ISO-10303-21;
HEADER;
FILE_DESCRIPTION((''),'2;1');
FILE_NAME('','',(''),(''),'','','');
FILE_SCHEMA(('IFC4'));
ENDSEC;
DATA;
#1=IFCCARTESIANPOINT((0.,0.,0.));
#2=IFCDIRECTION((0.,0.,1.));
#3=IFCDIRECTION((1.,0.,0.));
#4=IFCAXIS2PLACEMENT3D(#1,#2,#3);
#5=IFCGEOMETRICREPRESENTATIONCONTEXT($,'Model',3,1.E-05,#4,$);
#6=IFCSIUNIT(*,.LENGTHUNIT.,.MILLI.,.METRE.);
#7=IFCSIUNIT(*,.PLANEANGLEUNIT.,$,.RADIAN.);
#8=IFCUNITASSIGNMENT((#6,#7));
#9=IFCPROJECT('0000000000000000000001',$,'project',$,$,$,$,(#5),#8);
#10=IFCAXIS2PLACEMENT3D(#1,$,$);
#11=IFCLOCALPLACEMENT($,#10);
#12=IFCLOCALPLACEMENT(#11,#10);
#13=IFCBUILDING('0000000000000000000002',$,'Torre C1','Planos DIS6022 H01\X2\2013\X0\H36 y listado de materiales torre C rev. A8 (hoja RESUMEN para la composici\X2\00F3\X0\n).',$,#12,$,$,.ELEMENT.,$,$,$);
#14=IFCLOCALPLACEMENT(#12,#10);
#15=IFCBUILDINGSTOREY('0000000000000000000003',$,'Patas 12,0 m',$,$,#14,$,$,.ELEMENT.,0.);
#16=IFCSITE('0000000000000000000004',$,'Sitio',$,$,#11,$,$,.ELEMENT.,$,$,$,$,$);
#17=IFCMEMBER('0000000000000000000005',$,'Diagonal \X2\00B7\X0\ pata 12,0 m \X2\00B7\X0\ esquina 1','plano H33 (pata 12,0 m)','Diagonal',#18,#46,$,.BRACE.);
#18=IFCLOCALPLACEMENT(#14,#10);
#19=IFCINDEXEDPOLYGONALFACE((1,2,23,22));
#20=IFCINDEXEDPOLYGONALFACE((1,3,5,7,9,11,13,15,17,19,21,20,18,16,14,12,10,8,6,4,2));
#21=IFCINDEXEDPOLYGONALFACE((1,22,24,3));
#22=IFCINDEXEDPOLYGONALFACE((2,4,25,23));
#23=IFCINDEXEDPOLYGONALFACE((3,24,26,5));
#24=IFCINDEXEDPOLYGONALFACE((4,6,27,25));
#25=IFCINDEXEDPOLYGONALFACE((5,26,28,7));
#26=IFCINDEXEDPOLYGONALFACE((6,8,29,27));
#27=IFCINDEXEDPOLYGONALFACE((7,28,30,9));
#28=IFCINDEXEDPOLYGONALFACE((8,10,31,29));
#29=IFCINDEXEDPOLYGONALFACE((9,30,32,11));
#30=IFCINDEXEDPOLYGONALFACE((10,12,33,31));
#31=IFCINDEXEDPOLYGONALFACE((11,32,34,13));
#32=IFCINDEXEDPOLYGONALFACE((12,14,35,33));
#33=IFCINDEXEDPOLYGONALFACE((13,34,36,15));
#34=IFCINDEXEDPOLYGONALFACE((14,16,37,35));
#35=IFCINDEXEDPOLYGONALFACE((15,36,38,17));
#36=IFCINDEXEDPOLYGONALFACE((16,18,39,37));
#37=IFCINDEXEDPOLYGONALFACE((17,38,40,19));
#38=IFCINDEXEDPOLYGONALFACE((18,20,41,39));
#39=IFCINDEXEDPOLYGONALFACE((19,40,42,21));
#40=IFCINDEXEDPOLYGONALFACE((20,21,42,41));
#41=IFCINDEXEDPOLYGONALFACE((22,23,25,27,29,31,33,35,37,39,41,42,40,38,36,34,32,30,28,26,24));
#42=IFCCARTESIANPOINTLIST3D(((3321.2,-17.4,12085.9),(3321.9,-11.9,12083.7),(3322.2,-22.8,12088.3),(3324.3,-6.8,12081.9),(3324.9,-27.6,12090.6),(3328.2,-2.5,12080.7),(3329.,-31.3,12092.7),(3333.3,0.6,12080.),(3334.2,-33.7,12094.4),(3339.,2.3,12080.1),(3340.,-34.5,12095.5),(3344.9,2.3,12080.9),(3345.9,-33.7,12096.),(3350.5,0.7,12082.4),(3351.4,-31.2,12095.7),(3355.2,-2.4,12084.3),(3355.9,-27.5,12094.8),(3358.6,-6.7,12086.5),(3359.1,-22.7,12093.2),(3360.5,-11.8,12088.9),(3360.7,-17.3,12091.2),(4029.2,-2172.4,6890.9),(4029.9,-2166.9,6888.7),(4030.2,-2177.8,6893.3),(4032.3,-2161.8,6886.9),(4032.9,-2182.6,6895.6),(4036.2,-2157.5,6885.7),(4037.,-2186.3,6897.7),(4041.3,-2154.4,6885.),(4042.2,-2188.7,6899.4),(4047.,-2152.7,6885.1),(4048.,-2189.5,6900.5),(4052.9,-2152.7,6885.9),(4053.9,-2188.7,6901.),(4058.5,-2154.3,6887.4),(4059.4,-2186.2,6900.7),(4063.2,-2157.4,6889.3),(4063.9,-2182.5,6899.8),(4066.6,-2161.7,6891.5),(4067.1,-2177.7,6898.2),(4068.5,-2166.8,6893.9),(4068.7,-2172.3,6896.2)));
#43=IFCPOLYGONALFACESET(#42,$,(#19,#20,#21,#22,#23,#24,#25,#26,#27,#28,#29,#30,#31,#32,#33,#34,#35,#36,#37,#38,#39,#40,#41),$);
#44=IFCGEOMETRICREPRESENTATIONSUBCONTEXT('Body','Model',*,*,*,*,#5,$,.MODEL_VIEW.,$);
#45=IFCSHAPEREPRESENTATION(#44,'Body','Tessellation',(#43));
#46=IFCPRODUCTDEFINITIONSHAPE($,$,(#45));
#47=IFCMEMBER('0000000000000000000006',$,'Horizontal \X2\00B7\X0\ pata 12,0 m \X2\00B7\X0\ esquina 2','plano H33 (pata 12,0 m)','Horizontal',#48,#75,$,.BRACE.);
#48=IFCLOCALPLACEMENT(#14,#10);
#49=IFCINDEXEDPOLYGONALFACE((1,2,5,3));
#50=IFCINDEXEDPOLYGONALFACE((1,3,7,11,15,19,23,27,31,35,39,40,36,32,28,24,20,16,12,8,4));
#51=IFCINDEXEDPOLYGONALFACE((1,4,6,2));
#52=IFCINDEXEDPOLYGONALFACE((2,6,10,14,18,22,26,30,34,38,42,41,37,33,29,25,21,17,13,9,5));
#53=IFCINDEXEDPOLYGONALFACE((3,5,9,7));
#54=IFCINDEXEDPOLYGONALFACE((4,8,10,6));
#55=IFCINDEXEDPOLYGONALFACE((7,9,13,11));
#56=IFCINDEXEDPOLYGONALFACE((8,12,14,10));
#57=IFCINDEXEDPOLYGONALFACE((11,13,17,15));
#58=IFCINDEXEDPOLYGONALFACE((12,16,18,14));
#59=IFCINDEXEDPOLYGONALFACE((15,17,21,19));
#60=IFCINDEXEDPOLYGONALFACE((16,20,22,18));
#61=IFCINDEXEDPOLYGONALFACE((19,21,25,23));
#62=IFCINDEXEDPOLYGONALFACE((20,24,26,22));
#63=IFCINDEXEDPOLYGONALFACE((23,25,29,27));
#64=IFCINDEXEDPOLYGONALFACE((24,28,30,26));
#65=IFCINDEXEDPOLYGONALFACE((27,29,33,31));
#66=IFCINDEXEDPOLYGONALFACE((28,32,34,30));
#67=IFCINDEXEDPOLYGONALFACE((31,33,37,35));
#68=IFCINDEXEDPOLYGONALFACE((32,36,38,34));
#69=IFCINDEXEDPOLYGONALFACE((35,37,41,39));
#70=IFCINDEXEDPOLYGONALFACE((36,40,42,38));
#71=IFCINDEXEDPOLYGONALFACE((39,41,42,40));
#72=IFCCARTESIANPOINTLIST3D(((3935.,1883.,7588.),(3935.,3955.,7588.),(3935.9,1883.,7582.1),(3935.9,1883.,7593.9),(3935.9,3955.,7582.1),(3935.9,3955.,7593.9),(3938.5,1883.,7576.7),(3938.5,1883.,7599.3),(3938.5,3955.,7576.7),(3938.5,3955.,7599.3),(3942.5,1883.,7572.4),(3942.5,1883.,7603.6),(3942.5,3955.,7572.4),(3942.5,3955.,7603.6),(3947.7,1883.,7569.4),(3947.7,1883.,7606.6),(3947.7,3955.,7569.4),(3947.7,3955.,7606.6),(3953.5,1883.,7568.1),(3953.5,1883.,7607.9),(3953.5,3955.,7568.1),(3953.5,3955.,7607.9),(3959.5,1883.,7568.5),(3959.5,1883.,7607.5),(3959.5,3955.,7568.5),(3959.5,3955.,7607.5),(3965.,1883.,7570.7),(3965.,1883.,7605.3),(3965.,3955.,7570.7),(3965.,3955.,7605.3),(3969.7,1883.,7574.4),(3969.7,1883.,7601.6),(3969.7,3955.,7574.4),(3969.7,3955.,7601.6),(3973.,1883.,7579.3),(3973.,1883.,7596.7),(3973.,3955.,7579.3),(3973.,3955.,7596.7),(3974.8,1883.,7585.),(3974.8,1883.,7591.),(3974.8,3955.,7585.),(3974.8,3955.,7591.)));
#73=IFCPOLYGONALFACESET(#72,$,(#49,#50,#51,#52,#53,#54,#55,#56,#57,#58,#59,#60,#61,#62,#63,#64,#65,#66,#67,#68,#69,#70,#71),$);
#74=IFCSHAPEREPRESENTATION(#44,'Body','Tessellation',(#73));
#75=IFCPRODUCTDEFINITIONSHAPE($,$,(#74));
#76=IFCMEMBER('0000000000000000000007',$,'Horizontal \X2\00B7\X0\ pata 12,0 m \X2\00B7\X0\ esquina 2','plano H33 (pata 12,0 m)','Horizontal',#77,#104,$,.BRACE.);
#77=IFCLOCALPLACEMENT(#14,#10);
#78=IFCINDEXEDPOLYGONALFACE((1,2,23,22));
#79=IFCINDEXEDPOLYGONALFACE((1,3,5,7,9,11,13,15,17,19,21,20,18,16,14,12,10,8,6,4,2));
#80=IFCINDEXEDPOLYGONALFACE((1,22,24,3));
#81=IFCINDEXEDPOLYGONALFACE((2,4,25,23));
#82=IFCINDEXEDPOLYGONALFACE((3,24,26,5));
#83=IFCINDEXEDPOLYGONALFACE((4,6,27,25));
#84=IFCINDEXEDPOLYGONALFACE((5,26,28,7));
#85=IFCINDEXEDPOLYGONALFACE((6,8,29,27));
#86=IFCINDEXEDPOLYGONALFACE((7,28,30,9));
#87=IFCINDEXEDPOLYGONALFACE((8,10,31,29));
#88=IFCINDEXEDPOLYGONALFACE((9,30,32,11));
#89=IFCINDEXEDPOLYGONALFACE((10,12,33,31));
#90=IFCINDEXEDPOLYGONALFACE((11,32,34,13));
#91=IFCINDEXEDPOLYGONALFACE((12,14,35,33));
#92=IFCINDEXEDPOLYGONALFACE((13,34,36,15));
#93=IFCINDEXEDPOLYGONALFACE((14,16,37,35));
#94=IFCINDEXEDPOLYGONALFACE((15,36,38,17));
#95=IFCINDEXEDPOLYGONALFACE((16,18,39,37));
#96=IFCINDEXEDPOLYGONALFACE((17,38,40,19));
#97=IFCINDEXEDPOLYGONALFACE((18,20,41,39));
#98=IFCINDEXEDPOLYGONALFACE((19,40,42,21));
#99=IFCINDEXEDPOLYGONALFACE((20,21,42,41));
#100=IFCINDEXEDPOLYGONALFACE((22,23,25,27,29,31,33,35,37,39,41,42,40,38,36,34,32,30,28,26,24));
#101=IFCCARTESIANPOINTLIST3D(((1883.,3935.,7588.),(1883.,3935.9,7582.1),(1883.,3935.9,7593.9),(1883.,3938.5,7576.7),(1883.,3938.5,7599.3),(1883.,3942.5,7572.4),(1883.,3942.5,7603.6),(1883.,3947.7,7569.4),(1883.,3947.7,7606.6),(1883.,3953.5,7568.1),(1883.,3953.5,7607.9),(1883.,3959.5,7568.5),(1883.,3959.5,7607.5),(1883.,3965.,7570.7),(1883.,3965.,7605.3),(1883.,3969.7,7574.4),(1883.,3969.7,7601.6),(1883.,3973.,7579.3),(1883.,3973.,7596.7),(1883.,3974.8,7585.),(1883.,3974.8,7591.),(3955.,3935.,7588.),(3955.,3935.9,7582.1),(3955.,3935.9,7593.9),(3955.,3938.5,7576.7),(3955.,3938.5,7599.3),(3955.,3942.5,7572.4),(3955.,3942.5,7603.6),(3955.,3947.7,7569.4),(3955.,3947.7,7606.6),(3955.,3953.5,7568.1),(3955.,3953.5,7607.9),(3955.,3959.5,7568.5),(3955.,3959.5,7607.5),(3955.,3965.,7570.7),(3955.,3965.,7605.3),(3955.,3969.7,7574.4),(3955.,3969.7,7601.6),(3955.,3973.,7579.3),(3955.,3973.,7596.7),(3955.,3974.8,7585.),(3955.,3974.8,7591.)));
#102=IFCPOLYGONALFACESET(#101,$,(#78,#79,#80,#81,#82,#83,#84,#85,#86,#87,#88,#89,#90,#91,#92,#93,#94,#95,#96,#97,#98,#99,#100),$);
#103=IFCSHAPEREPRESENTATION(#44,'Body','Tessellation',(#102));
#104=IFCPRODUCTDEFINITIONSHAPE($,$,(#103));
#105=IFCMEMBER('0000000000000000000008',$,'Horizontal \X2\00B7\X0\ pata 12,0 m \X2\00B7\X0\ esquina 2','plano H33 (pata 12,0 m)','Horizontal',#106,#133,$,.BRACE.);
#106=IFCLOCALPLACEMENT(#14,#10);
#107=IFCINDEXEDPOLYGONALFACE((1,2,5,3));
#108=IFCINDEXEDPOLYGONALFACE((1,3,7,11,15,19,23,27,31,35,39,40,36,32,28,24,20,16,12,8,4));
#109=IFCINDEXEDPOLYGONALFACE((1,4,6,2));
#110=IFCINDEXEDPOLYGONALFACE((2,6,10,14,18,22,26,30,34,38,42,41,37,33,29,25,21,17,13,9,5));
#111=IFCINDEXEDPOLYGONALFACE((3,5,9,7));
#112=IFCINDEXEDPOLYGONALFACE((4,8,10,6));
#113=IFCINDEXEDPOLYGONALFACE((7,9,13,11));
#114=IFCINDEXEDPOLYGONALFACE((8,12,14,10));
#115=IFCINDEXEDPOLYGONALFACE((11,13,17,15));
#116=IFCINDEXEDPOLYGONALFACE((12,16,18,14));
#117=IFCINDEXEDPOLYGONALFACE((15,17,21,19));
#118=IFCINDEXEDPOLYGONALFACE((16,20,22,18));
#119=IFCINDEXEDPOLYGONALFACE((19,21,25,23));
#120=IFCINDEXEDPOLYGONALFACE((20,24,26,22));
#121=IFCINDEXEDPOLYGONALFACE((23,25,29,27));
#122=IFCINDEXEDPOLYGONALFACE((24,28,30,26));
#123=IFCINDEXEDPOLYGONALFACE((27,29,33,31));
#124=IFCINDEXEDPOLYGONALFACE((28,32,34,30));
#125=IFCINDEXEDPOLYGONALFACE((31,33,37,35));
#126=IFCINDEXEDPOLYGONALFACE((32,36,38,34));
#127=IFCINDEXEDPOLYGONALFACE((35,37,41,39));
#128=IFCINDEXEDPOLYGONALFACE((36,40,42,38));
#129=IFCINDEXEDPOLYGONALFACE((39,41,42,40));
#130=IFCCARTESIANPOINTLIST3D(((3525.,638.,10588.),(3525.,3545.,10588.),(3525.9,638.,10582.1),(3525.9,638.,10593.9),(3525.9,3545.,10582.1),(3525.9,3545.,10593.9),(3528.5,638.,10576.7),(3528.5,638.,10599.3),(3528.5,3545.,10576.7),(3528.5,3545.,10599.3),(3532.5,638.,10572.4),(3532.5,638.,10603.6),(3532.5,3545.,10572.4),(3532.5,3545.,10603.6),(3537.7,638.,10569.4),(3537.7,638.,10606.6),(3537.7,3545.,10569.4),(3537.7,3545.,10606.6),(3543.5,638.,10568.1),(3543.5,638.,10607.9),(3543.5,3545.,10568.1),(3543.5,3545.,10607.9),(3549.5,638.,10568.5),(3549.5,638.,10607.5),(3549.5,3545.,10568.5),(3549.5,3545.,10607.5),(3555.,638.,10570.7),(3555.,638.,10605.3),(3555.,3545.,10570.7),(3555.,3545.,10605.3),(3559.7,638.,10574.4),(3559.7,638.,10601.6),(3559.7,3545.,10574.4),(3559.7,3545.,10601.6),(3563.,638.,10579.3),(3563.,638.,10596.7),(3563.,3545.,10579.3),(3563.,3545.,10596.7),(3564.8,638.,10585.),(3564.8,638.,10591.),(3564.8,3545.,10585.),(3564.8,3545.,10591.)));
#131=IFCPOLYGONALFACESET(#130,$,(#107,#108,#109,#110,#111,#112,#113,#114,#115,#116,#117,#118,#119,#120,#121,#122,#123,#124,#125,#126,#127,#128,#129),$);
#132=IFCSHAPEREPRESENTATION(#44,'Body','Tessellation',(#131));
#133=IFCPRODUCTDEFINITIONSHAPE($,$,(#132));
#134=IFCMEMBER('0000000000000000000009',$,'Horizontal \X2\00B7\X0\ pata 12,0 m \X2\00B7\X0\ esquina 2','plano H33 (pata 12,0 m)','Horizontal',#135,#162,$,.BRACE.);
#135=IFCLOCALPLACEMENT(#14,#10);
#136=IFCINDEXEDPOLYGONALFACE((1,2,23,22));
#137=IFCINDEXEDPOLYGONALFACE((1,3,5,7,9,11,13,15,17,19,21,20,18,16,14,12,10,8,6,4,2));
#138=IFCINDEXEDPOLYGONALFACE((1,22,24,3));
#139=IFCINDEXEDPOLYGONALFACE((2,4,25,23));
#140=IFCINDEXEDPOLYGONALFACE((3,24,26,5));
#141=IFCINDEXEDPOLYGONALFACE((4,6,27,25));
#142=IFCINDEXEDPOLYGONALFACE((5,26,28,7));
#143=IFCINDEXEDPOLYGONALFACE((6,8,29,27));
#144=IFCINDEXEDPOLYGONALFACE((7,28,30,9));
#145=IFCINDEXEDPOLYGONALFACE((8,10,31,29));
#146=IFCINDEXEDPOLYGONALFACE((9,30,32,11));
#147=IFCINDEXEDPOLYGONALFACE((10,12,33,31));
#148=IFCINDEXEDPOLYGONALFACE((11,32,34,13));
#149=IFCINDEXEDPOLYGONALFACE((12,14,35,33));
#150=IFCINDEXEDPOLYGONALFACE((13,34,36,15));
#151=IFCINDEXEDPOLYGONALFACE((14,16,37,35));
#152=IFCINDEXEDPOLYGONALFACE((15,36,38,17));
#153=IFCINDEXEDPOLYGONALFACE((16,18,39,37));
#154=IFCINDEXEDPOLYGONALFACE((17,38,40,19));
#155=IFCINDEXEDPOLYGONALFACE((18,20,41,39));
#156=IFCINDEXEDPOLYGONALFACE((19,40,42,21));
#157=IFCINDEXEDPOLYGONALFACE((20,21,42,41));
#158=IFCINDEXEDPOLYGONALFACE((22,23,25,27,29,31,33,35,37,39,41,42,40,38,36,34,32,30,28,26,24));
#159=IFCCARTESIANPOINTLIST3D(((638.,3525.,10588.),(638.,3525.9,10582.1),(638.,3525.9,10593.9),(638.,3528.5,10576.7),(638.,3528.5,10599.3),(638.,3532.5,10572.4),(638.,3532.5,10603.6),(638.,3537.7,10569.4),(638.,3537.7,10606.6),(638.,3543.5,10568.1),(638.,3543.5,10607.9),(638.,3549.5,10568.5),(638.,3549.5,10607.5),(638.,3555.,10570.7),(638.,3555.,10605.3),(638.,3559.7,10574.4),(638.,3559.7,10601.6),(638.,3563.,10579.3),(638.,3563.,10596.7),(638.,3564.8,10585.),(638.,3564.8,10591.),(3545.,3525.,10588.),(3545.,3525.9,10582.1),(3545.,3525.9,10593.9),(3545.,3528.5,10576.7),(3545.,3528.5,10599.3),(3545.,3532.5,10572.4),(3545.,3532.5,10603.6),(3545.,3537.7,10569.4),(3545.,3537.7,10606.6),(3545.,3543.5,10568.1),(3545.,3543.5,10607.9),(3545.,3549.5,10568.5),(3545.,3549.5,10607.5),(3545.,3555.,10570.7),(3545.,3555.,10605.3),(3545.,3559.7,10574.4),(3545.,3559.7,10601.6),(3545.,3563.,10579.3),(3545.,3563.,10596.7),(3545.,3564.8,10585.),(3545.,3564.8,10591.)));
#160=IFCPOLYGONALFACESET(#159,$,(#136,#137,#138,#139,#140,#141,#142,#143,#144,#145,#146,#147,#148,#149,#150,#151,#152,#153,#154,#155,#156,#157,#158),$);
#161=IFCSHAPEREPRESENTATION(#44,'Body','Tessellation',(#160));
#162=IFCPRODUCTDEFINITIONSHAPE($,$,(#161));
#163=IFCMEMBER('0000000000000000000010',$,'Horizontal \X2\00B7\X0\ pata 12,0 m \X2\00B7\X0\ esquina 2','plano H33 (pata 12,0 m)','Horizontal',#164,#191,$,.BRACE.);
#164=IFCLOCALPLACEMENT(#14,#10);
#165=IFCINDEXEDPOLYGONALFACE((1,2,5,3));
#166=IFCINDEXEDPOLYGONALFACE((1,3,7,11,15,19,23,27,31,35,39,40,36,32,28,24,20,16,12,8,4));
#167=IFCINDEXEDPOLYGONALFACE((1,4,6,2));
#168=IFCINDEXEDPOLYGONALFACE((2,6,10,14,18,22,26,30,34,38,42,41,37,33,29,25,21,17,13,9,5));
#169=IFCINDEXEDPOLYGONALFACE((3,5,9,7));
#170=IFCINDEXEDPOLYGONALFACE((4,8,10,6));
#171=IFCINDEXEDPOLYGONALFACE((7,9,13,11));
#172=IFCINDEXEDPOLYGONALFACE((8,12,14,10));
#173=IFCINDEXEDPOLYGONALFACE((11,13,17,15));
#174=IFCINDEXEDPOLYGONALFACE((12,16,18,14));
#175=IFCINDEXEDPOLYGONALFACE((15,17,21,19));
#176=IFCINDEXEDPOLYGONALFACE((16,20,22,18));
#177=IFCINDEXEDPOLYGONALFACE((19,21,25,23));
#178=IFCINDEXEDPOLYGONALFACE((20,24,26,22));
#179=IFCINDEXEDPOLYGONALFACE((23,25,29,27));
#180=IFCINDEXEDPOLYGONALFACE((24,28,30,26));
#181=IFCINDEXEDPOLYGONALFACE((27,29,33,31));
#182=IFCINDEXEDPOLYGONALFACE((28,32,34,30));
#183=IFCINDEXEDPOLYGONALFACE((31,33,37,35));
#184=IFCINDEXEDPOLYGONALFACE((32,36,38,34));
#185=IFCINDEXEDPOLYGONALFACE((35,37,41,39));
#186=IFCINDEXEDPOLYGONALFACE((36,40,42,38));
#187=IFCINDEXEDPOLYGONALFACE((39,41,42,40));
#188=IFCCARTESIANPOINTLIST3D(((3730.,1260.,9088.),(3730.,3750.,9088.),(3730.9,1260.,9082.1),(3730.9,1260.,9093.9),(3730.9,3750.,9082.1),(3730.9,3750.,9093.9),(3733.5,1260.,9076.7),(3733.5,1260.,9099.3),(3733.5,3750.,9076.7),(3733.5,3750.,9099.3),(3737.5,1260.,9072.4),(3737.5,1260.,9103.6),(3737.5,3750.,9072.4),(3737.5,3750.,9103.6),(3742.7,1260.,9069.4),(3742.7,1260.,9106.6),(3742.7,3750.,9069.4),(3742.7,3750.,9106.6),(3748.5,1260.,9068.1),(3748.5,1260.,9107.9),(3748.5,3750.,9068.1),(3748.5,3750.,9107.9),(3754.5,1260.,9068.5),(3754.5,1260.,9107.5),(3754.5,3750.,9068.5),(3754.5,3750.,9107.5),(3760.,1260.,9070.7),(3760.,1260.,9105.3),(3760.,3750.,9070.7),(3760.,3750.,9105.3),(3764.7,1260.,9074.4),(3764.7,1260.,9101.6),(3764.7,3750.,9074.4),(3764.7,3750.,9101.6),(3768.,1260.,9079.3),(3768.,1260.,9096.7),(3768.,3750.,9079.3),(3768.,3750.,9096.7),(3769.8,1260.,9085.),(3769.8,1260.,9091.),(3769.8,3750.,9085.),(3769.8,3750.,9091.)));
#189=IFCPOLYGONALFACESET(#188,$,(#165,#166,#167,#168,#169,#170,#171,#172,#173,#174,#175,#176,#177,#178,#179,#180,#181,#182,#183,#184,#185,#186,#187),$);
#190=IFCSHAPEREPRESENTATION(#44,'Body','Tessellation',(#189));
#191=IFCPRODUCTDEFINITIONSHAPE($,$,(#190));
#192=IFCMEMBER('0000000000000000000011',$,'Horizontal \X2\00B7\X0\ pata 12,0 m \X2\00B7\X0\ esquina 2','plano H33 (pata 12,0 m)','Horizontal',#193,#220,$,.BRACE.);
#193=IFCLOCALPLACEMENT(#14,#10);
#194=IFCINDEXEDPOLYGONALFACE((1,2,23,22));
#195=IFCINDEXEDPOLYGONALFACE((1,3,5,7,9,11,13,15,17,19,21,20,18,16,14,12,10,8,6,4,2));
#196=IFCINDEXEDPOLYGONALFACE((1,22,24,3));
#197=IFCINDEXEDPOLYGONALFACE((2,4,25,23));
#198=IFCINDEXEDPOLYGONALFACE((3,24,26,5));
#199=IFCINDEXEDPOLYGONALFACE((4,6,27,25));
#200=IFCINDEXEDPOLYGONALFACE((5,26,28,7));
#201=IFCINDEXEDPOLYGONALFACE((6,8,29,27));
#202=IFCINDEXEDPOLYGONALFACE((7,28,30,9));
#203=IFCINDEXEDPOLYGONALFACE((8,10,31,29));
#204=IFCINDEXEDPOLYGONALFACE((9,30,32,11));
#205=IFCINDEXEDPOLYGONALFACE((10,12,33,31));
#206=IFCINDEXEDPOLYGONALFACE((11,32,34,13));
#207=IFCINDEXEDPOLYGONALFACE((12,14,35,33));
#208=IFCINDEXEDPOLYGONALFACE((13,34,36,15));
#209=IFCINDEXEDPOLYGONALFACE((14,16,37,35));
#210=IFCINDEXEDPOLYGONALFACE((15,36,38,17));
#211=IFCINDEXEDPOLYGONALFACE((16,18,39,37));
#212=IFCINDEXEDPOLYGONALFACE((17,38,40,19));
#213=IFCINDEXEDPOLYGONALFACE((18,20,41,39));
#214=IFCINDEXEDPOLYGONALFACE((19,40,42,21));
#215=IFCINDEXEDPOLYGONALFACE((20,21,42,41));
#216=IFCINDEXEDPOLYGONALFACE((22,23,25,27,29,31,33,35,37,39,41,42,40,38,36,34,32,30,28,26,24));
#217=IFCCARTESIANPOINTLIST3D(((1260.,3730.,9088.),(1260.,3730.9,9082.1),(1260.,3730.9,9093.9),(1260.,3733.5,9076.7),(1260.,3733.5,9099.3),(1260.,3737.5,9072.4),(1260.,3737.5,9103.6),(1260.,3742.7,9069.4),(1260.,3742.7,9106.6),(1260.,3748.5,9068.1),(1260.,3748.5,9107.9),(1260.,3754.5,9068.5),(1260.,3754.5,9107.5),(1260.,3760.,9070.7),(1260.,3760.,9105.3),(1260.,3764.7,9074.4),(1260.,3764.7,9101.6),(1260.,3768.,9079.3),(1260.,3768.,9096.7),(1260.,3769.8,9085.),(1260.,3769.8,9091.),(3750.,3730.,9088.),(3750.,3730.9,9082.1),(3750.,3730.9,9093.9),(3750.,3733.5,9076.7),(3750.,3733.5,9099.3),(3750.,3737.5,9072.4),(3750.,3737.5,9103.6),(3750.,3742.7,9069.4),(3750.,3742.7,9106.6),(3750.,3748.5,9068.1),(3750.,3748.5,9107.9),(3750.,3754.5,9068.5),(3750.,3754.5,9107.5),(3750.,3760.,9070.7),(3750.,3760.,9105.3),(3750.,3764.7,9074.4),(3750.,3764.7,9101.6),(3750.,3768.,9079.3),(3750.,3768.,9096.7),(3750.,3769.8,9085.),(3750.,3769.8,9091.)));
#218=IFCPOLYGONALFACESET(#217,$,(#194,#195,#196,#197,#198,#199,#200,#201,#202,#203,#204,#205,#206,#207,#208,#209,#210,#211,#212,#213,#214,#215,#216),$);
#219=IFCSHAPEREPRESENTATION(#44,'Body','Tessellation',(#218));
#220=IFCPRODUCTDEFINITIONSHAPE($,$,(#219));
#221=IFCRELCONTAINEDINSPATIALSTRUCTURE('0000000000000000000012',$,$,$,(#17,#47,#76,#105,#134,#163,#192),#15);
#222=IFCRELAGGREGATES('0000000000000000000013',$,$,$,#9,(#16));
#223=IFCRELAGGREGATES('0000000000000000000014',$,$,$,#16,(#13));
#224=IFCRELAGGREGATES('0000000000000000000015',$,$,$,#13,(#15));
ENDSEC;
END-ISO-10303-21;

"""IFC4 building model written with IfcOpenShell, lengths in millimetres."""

from ifc_helpers import new_model, si_unit, frame, origin, origin_with_axes, place, context, subcontext, project, spatial, circle, extrude, element, save


model = new_model("IFC4")

# Units and contexts
model_context = context("Model", 3, precision=1e-05, world=origin_with_axes())
body_context = subcontext(model_context, "Body", "Model", "MODEL_VIEW")
ifc_project = project(units=[si_unit("LENGTHUNIT", "METRE", prefix="MILLI"), si_unit("PLANEANGLEUNIT", "RADIAN")], contexts=[model_context])

# Site, building, storey
site_placement = place(None, origin())
site = spatial("IfcSite", under=ifc_project, at=site_placement, Name="Sitio", CompositionType="ELEMENT")
building_placement = place(site_placement, origin())
building = spatial("IfcBuilding", under=site, at=building_placement, Name="Torre C1", Description="Planos DIS6022 H01–H36 y listado de materiales torre C rev. A8 (hoja RESUMEN para la composición).", CompositionType="ELEMENT")
storey_placement = place(building_placement, origin())
storey = spatial("IfcBuildingStorey", under=building, at=storey_placement, Name="Patas 12,0 m", CompositionType="ELEMENT", Elevation=0.0)

# Members
member_1_placement = place(storey_placement, frame((3341.0, -16.0, 12088.0), z_axis=(0.124898, -0.380163, -0.916448), x_axis=(-0.955547, 0.202551, -0.214249)))
element("IfcMember", 1, at=member_1_placement, inside=storey, Name="Diagonal · pata 12,0 m · esquina 1", Description="plano H33 (pata 12,0 m)", ObjectType="Diagonal", PredefinedType="BRACE", context=body_context, shape_type="SweptSolid", body=[
    extrude(circle(Radius=20.0), None, (0.0, 0.0, 1.0), 5668.6),
])
for number, where, z_axis, x_axis, name in (
    (2, (3955.0, 1883.0, 7588.0), (0.0, 1.0, 0.0), (-1.0, 0.0, 0.0), "Horizontal · pata 12,0 m · esquina 2"),
    (3, (1883.0, 3955.0, 7588.0), (1.0, 0.0, 0.0), (0.0, -1.0, 0.0), "Horizontal · pata 12,0 m · esquina 2"),
):
    element("IfcMember", number, at=place(storey_placement, frame(where, z_axis=z_axis, x_axis=x_axis)), inside=storey, Name=name, Description="plano H33 (pata 12,0 m)", ObjectType="Horizontal", PredefinedType="BRACE", context=body_context, shape_type="SweptSolid", body=[
        extrude(circle(Radius=20.0), None, (0.0, 0.0, 1.0), 2072.0),
    ])
for number, where, z_axis, x_axis, name in (
    (4, (3545.0, 3545.0, 10588.0), (0.0, -1.0, 0.0), (-1.0, 0.0, 0.0), "Horizontal · pata 12,0 m · esquina 2"),
    (5, (3545.0, 3545.0, 10588.0), (-1.0, 0.0, 0.0), (0.0, -1.0, 0.0), "Horizontal · pata 12,0 m · esquina 2"),
):
    element("IfcMember", number, at=place(storey_placement, frame(where, z_axis=z_axis, x_axis=x_axis)), inside=storey, Name=name, Description="plano H33 (pata 12,0 m)", ObjectType="Horizontal", PredefinedType="BRACE", context=body_context, shape_type="SweptSolid", body=[
        extrude(circle(Radius=20.0), None, (0.0, 0.0, 1.0), 2907.0),
    ])
for number, where, z_axis, x_axis, name in (
    (6, (3750.0, 3750.0, 9088.0), (0.0, -1.0, 0.0), (-1.0, 0.0, 0.0), "Horizontal · pata 12,0 m · esquina 2"),
    (7, (3750.0, 3750.0, 9088.0), (-1.0, 0.0, 0.0), (0.0, -1.0, 0.0), "Horizontal · pata 12,0 m · esquina 2"),
):
    element("IfcMember", number, at=place(storey_placement, frame(where, z_axis=z_axis, x_axis=x_axis)), inside=storey, Name=name, Description="plano H33 (pata 12,0 m)", ObjectType="Horizontal", PredefinedType="BRACE", context=body_context, shape_type="SweptSolid", body=[
        extrude(circle(Radius=20.0), None, (0.0, 0.0, 1.0), 2490.0),
    ])

save(model, "model.ifc")
